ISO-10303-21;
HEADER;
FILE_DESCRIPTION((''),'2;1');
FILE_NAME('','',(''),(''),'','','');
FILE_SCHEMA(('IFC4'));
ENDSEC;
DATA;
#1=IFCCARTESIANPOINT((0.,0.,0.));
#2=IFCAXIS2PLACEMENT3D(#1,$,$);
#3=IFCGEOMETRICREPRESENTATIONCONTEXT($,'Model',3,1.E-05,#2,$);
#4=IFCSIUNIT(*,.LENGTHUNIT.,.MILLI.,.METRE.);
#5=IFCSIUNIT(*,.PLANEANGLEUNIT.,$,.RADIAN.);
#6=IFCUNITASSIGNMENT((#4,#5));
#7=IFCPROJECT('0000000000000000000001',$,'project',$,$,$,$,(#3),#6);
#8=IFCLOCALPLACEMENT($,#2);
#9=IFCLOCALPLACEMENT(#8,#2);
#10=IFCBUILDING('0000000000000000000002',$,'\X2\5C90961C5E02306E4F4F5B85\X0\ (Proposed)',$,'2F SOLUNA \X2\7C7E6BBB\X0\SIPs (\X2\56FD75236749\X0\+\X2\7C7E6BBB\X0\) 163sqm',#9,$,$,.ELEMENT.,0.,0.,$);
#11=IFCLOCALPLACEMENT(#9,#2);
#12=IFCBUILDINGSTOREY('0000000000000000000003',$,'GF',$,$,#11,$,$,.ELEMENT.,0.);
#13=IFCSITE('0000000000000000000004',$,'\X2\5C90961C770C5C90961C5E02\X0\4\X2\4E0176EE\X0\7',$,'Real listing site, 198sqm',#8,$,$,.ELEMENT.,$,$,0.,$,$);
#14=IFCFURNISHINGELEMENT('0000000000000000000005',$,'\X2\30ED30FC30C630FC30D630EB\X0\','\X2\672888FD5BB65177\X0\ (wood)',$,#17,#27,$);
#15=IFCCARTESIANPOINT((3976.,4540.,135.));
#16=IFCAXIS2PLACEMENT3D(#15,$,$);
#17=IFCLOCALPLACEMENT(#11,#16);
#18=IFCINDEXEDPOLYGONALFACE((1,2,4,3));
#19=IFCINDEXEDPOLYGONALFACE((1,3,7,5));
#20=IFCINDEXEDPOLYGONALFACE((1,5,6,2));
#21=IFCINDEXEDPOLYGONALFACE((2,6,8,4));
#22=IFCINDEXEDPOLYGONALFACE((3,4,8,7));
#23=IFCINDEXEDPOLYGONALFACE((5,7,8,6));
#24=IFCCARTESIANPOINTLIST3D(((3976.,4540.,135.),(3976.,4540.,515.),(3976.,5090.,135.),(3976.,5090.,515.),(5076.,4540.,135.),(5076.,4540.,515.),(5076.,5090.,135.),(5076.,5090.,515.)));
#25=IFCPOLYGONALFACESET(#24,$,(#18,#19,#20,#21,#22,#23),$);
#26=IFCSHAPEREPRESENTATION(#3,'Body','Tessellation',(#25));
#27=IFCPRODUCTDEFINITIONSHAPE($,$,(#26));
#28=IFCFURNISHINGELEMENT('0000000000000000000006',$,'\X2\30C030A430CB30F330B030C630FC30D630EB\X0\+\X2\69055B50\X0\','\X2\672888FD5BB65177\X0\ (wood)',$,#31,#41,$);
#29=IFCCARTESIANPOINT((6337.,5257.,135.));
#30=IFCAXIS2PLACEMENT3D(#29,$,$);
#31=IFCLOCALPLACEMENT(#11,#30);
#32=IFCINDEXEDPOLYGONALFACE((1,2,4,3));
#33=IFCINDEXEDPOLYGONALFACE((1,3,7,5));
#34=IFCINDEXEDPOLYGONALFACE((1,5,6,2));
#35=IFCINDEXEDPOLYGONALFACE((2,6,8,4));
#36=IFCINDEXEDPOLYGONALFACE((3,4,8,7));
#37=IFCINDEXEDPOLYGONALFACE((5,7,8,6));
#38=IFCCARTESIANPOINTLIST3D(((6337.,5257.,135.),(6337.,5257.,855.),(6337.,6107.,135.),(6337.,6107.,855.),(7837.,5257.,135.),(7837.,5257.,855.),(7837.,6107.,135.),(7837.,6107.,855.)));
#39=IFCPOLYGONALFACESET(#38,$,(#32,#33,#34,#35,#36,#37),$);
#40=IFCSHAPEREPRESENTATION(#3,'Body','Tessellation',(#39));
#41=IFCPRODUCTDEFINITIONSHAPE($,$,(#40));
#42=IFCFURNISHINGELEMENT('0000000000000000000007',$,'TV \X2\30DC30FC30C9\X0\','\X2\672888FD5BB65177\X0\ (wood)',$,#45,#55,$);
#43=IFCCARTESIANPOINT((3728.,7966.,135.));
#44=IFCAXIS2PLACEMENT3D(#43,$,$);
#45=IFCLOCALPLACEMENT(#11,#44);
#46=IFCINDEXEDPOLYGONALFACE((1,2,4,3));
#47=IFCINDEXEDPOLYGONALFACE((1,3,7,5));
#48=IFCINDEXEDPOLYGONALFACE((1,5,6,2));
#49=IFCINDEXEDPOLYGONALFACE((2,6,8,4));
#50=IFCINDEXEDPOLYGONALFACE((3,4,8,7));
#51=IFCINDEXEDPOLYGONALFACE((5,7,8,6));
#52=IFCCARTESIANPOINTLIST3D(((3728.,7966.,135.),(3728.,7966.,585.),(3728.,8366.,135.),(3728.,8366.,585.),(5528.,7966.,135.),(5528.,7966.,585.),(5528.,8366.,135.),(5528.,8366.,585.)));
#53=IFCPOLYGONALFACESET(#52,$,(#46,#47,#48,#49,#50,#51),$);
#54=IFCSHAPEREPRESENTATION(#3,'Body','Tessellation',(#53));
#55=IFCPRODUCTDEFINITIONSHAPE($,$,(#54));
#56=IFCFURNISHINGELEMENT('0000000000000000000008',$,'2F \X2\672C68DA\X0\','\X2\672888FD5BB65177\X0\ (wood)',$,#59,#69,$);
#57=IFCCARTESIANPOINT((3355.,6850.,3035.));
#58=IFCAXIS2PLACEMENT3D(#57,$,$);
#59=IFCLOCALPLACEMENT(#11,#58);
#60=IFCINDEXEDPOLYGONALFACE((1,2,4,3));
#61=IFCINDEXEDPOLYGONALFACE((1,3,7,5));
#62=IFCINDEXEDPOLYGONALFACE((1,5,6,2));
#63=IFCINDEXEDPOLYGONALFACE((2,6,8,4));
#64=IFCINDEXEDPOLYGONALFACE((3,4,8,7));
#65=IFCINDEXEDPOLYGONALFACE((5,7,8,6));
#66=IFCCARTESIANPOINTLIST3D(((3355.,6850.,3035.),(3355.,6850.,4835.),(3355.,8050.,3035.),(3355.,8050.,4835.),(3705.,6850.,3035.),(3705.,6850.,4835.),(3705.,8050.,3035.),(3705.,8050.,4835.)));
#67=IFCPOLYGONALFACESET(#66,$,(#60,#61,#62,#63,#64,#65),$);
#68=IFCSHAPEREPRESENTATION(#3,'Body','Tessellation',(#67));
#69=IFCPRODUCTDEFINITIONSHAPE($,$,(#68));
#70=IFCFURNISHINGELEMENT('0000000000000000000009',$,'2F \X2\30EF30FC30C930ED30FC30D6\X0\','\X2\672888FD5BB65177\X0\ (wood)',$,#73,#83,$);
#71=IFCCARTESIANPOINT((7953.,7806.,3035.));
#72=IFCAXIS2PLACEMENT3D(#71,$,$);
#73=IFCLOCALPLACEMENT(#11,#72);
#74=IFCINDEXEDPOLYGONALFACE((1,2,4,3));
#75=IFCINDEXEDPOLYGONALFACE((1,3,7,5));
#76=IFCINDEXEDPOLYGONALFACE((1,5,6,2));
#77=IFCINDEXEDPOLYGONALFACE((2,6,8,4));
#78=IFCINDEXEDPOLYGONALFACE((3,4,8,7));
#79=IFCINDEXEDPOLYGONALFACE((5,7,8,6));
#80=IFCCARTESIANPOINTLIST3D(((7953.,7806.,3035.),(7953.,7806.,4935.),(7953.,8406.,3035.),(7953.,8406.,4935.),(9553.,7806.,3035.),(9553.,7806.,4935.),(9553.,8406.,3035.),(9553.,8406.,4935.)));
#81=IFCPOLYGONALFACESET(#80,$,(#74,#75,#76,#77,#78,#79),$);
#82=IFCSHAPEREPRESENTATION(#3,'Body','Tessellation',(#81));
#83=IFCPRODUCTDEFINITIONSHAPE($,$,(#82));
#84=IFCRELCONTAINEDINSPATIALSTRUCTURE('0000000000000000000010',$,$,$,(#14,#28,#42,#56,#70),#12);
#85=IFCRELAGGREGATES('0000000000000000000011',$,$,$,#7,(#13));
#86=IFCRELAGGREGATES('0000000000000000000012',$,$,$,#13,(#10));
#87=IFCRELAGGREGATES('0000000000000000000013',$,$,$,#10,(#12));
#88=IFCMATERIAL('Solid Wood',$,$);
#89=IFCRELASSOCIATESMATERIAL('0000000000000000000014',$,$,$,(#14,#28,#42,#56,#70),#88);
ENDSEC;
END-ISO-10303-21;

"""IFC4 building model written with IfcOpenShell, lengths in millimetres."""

from ifc_helpers import new_model, si_unit, frame, frame_2d, origin, place, context, project, spatial, rectangle, extrude, material, element, save


model = new_model("IFC4")

# Units and contexts
model_context = context("Model", 3, precision=1e-05, world=origin())
ifc_project = project(units=[si_unit("LENGTHUNIT", "METRE", prefix="MILLI"), si_unit("PLANEANGLEUNIT", "RADIAN")], contexts=[model_context])

# Site, building, storey
site_placement = place(None, origin())
site = spatial("IfcSite", under=ifc_project, at=site_placement, Name="岐阜県岐阜市4丁目7", ObjectType="Real listing site, 198sqm", CompositionType="ELEMENT", RefElevation=0.0)
building_placement = place(site_placement, origin())
building = spatial("IfcBuilding", under=site, at=building_placement, Name="岐阜市の住宅 (Proposed)", ObjectType="2F SOLUNA 籾殻SIPs (国産杉+籾殻) 163sqm", CompositionType="ELEMENT", ElevationOfRefHeight=0.0, ElevationOfTerrain=0.0)
storey_placement = place(building_placement, origin())
storey = spatial("IfcBuildingStorey", under=building, at=storey_placement, Name="GF", CompositionType="ELEMENT", Elevation=0.0)

# Shared definitions
ifc_material_1 = material(Name="Solid Wood")

# Furnishing elements
furnishing_1_placement = place(storey_placement, frame((3976.0, 4540.0, 135.0)))
element("IfcFurnishingElement", 1, at=furnishing_1_placement, inside=storey, material=ifc_material_1, Name="ローテーブル", Description="木製家具 (wood)", context=model_context, shape_type="SweptSolid", body=[
    extrude(rectangle(XDim=1100.0, YDim=550.0, at=frame_2d((550.0, 275.0))), frame((3976.0, 4540.0, 135.0)), (0.0, 0.0, 1.0), 380.0),
])
furnishing_2_placement = place(storey_placement, frame((6337.0, 5257.0, 135.0)))
element("IfcFurnishingElement", 2, at=furnishing_2_placement, inside=storey, material=ifc_material_1, Name="ダイニングテーブル+椅子", Description="木製家具 (wood)", context=model_context, shape_type="SweptSolid", body=[
    extrude(rectangle(XDim=1500.0, YDim=850.0, at=frame_2d((750.0, 425.0))), frame((6337.0, 5257.0, 135.0)), (0.0, 0.0, 1.0), 720.0),
])
furnishing_3_placement = place(storey_placement, frame((3728.0, 7966.0, 135.0)))
element("IfcFurnishingElement", 3, at=furnishing_3_placement, inside=storey, material=ifc_material_1, Name="TV ボード", Description="木製家具 (wood)", context=model_context, shape_type="SweptSolid", body=[
    extrude(rectangle(XDim=1800.0, YDim=400.0, at=frame_2d((900.0, 200.0))), frame((3728.0, 7966.0, 135.0)), (0.0, 0.0, 1.0), 450.0),
])
furnishing_4_placement = place(storey_placement, frame((3355.0, 6850.0, 3035.0)))
element("IfcFurnishingElement", 4, at=furnishing_4_placement, inside=storey, material=ifc_material_1, Name="2F 本棚", Description="木製家具 (wood)", context=model_context, shape_type="SweptSolid", body=[
    extrude(rectangle(XDim=350.0, YDim=1200.0, at=frame_2d((175.0, 600.0))), frame((3355.0, 6850.0, 3035.0)), (0.0, 0.0, 1.0), 1800.0),
])
furnishing_5_placement = place(storey_placement, frame((7953.0, 7806.0, 3035.0)))
element("IfcFurnishingElement", 5, at=furnishing_5_placement, inside=storey, material=ifc_material_1, Name="2F ワードローブ", Description="木製家具 (wood)", context=model_context, shape_type="SweptSolid", body=[
    extrude(rectangle(XDim=1600.0, YDim=600.0, at=frame_2d((800.0, 300.0))), frame((7953.0, 7806.0, 3035.0)), (0.0, 0.0, 1.0), 1900.0),
])

save(model, "model.ifc")
